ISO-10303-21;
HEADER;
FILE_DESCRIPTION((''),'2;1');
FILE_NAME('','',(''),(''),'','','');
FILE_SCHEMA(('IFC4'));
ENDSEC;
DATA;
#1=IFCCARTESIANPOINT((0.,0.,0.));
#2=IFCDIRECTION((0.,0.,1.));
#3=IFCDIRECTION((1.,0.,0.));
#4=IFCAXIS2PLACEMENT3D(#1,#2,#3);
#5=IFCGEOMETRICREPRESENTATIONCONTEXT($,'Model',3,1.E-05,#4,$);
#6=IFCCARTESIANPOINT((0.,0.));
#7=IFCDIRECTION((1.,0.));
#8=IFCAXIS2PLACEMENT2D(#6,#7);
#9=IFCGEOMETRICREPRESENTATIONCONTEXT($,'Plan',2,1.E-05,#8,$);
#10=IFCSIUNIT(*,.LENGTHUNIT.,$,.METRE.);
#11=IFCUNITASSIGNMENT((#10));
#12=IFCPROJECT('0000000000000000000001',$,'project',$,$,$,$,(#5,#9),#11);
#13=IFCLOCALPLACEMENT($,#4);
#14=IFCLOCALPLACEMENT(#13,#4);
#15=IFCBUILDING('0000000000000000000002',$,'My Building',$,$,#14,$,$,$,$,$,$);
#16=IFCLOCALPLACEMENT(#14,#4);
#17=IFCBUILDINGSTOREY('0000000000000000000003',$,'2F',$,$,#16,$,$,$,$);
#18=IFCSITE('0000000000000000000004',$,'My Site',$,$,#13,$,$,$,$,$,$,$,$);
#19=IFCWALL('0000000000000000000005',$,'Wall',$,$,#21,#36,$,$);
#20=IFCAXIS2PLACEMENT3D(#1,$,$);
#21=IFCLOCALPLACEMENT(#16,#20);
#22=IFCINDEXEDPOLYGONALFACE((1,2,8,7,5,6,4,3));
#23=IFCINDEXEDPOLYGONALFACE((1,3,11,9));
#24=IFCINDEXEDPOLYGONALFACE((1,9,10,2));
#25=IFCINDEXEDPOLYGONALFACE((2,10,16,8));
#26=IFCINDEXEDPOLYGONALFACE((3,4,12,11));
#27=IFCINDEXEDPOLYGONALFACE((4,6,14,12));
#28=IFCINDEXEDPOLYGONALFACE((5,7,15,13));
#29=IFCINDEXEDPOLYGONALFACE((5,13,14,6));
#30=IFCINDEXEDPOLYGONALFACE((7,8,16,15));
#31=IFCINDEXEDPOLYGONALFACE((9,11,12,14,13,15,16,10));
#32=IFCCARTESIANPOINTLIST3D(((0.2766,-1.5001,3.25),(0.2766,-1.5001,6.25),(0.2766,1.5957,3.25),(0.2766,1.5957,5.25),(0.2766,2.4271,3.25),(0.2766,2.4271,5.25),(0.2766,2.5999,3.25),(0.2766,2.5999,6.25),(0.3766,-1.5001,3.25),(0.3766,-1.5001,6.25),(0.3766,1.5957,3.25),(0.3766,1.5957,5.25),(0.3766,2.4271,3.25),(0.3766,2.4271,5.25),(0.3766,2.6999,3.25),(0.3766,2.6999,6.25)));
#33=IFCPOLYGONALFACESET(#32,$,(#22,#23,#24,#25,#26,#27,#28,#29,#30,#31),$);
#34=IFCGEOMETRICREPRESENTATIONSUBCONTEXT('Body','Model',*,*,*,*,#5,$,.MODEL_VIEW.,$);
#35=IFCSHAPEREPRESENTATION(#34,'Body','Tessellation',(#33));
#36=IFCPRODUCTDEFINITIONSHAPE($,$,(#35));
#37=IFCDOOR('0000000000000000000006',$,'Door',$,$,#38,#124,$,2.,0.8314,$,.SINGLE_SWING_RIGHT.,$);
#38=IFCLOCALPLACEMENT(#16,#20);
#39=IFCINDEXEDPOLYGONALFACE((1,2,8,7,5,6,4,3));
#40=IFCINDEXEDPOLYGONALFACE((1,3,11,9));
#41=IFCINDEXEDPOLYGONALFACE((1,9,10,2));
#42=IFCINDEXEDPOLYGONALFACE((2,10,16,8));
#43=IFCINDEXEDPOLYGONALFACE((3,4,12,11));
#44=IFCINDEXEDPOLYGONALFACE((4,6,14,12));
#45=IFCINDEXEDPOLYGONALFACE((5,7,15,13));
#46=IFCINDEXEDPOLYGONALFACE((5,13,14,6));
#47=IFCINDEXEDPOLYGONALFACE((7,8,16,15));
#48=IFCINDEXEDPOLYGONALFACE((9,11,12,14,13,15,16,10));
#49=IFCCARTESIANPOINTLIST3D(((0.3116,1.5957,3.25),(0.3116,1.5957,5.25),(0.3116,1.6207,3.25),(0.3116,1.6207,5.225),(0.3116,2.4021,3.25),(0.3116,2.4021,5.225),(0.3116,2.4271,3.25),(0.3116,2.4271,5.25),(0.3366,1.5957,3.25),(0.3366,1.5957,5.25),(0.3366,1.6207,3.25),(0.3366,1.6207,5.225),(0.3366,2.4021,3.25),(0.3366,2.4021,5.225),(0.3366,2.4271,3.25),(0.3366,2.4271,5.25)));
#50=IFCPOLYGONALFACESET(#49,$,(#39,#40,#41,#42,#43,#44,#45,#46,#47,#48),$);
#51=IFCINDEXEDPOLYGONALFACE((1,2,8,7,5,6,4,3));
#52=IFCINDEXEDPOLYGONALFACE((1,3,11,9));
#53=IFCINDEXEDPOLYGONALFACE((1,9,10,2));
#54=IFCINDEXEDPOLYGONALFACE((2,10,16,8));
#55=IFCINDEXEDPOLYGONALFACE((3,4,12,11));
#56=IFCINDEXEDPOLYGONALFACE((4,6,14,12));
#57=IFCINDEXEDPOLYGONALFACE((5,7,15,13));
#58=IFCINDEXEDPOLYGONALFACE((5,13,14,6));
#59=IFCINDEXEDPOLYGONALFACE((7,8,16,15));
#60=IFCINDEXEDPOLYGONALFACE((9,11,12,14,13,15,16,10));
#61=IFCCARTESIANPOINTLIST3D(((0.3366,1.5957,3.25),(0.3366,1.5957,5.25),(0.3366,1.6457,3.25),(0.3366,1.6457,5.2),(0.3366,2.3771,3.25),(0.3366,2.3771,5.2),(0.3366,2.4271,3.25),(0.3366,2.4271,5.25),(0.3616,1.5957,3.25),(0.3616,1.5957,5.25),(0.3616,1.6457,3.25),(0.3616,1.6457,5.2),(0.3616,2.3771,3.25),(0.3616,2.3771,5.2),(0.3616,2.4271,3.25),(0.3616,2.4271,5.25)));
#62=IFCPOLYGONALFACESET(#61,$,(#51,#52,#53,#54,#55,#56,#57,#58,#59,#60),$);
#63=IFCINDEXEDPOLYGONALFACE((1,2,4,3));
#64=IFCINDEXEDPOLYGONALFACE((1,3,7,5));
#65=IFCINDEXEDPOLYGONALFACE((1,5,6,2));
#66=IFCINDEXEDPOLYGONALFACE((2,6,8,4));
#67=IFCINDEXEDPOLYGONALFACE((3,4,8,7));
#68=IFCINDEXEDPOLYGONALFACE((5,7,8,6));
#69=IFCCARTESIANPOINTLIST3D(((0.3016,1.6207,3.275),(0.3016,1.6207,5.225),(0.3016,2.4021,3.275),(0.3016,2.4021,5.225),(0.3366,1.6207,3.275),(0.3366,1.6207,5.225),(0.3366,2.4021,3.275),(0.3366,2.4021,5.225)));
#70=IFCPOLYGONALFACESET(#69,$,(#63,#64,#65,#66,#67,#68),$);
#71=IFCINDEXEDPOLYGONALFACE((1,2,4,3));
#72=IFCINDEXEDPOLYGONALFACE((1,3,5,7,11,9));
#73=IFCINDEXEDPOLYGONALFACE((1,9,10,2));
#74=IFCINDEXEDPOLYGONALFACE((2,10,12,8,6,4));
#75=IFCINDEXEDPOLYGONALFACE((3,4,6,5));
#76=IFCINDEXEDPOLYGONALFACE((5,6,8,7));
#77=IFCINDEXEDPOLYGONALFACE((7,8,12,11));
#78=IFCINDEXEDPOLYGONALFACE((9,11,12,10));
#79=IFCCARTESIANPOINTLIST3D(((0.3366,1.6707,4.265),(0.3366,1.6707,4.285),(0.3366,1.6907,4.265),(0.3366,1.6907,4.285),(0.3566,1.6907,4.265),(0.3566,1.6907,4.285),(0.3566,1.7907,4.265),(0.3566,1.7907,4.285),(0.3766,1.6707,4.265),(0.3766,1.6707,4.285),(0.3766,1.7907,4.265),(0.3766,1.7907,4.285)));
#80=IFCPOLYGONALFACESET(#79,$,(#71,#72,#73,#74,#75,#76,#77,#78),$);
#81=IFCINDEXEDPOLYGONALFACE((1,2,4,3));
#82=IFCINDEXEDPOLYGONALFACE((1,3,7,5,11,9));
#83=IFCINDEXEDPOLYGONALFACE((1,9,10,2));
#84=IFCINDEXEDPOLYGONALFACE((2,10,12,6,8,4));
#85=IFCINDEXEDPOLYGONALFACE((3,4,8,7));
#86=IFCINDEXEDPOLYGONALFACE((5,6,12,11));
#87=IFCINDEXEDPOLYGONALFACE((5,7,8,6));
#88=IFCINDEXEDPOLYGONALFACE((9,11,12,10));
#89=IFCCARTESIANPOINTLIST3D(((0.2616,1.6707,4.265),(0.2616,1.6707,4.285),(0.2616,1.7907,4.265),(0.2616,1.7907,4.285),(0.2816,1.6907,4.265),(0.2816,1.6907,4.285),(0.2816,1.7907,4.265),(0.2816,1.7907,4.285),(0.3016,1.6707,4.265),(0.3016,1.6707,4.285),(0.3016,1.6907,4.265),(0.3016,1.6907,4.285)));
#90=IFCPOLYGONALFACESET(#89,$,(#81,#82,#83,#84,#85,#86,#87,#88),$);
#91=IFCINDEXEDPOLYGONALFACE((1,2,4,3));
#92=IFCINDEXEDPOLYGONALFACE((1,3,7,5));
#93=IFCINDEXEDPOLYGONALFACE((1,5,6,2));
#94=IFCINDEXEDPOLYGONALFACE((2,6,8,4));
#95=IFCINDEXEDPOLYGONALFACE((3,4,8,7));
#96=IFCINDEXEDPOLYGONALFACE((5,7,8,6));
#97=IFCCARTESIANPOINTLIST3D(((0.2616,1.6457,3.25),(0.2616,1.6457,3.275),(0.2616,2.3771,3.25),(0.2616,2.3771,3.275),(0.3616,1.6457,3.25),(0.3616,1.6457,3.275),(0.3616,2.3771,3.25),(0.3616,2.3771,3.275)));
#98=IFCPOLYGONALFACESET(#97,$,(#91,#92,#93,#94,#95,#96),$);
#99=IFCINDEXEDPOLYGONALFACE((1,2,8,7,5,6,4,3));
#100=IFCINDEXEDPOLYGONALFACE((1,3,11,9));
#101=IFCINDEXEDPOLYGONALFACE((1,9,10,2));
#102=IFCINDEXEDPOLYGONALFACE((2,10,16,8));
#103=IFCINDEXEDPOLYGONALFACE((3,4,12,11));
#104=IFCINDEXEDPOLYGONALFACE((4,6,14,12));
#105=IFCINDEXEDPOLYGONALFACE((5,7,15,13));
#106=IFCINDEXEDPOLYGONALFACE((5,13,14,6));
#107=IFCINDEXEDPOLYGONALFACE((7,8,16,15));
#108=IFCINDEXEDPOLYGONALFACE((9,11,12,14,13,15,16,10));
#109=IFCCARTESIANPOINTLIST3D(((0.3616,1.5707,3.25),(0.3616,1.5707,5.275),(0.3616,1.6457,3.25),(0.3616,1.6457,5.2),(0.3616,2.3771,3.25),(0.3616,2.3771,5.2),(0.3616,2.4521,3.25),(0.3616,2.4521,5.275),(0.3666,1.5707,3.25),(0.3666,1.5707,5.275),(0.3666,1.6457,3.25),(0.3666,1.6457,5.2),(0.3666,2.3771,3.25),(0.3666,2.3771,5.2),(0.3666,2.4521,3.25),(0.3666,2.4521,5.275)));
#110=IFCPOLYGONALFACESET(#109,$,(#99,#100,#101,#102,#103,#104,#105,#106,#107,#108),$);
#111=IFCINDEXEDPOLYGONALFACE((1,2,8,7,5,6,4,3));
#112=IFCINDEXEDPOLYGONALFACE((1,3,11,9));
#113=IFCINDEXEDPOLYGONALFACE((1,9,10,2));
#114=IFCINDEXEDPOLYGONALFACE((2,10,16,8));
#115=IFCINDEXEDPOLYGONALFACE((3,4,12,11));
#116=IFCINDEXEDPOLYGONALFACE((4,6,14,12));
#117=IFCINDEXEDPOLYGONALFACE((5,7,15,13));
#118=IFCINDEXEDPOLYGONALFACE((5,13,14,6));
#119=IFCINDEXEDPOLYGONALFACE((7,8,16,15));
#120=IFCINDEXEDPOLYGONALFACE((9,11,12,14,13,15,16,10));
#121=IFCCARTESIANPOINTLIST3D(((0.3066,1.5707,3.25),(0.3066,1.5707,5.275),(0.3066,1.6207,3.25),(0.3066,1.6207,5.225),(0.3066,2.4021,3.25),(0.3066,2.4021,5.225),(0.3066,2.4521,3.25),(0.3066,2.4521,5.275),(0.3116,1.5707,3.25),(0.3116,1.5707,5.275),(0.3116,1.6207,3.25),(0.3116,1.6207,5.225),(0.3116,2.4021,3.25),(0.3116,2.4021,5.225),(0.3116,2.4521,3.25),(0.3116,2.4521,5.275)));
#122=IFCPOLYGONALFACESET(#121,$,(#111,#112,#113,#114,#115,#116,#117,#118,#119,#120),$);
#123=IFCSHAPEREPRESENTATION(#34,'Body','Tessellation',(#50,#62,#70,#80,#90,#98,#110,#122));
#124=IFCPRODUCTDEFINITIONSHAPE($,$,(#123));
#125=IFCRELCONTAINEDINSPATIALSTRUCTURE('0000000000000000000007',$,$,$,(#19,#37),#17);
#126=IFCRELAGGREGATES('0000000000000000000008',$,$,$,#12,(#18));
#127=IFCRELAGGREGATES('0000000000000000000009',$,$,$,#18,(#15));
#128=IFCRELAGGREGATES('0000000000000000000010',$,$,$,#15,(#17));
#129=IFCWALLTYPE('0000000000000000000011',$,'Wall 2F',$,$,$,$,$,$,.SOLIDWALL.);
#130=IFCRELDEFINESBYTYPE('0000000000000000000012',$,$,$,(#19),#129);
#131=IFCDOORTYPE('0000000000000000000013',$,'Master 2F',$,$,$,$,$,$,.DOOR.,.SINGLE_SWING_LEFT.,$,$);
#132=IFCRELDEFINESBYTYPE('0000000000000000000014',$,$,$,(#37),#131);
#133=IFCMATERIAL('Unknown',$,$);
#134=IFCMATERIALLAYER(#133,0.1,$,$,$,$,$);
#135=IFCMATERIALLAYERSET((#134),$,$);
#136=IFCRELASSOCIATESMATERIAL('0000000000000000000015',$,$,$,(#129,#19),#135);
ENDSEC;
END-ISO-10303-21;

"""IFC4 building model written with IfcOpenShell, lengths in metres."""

from ifc_helpers import new_model, entity, si_unit, frame, origin_with_axes, origin_2d_with_axis, place, context, subcontext, project, spatial, line, indexed_curve, outline, extrude, shape, source, transform, mapped, material, layer, layer_set, layer_usage, type_object, type_shapes, element, fill, save


model = new_model("IFC4")

# Units and contexts
model_context = context("Model", 3, precision=1e-05, world=origin_with_axes())
plan_context = context("Plan", 2, precision=1e-05, world=origin_2d_with_axis())
body_context_1 = subcontext(model_context, "Body", "Model", "MODEL_VIEW")
body_context_2 = subcontext(plan_context, "Body", "Plan", "PLAN_VIEW")
ifc_project = project(units=[si_unit("LENGTHUNIT", "METRE")], contexts=[model_context, plan_context])

# Site, building, storey
site_placement = place(None, origin_with_axes())
site = spatial("IfcSite", under=ifc_project, at=site_placement, Name="My Site")
building_placement = place(site_placement, origin_with_axes())
building = spatial("IfcBuilding", under=site, at=building_placement, Name="My Building")
storey_placement = place(building_placement, origin_with_axes())
storey = spatial("IfcBuildingStorey", under=building, at=storey_placement, Name="2F")

# Shared definitions
ifc_material = material(Name="Unknown")

# Shared definitions
ifc_layer = layer(ifc_material, 0.1)
ifc_layer_set = layer_set([ifc_layer])
wall_type = type_object("IfcWallType", Name="Wall 2F", PredefinedType="SOLIDWALL", material=ifc_layer_set)

# Wall, opening, door
ifc_layer_usage_1 = layer_usage(ifc_layer_set, "AXIS2", "POSITIVE", 0.0)
wall_1_placement = place(storey_placement, frame((0.3766, -1.6001, 3.25), z_axis=(0.0, 0.0, 1.0), x_axis=(0.0, 1.0, 0.0)))
wall_1 = element("IfcWall", 1, at=wall_1_placement, inside=storey, type_object=wall_type, material=ifc_layer_usage_1, Name="Wall", context=body_context_1, shape_type="SweptSolid", body=[
    extrude(outline(indexed_curve([(0.1, 0.0), (0.1, 0.1), (4.2, 0.1), (4.3, 0.0)], segments=[line(1, 2, 3, 4, 1)])), origin_with_axes(), (0.0, 0.0, 1.0), 3.0),
])
shared_shape_1 = source(origin_with_axes(), body_context_1, "Body", "SweptSolid", [
    extrude(outline(indexed_curve([(0.0, 0.0), (0.8314, 0.0), (0.8314, 2.0), (0.0, 2.0)], segments=[line(1, 2, 3, 4, 1)])), frame((0.0, -0.6, 0.0), z_axis=(0.0, -1.0, 0.0), x_axis=(1.0, 0.0, 0.0)), (0.0, 0.0, -1.0), 1.2),
])
opening_1_placement = place(wall_1_placement, frame((3.1958, 0.015, 0.0), z_axis=(0.0, 0.0, 1.0), x_axis=(1.0, 0.0, 0.0)))
opening_1 = element("IfcOpeningElement", 2, at=opening_1_placement, cuts=wall_1, PredefinedType="OPENING", context=body_context_1, shape_type="MappedRepresentation", body=[
    mapped(shared_shape_1, transform((0.0, 0.0, 0.0), x_axis=(1.0, 0.0, 0.0), y_axis=(0.0, 1.0, 0.0), z_axis=(0.0, 0.0, 1.0), scale=1.0)),
])
door_type_1 = type_object("IfcDoorType", Name="Master 2F", OperationType="SINGLE_SWING_LEFT", PredefinedType="DOOR")
shared_shape_2 = source(origin_with_axes(), body_context_1, "Body", "SweptSolid", [
    extrude(outline(indexed_curve([(0.0, 0.0), (0.0, 2.0), (0.8314, 2.0), (0.8314, 0.0), (0.8064, 0.0), (0.8064, 1.975), (0.025, 1.975), (0.025, 0.0)], segments=[line(1, 2, 3, 4, 5, 6, 7, 8, 1)])), frame((0.0, 0.025, 0.0), z_axis=(0.0, -1.0, 0.0), x_axis=(1.0, 0.0, 0.0)), (0.0, 0.0, -1.0), 0.025),
    extrude(outline(indexed_curve([(0.0, 0.0), (0.0, 2.0), (0.8314, 2.0), (0.8314, 0.0), (0.7814, 0.0), (0.7814, 1.95), (0.05, 1.95), (0.05, 0.0)], segments=[line(1, 2, 3, 4, 5, 6, 7, 8, 1)])), frame((0.0, 0.0, 0.0), z_axis=(0.0, -1.0, 0.0), x_axis=(1.0, 0.0, 0.0)), (0.0, 0.0, -1.0), 0.025),
    extrude(outline(indexed_curve([(0.0, 0.0), (0.7814, 0.0), (0.7814, 0.035), (0.0, 0.035)], segments=[line(1, 2, 3, 4, 1)])), frame((0.025, 0.025, 0.025), z_axis=(0.0, 0.0, 1.0), x_axis=(1.0, 0.0, 0.0)), (0.0, 0.0, 1.0), 1.95),
    extrude(outline(indexed_curve([(0.0, 0.0), (0.0, -0.04), (0.12, -0.04), (0.12, -0.02), (0.02, -0.02), (0.02, 0.0)], segments=[line(1, 2, 3, 4, 5, 6, 1)])), frame((0.075, 0.025, 1.015), z_axis=(0.0, 0.0, 1.0), x_axis=(1.0, 0.0, 0.0)), (0.0, 0.0, 1.0), 0.02),
    extrude(outline(indexed_curve([(0.0, 0.0), (0.0, 0.04), (0.12, 0.04), (0.12, 0.02), (0.02, 0.02), (0.02, 0.0)], segments=[line(1, 2, 3, 4, 5, 6, 1)])), frame((0.075, 0.06, 1.015), z_axis=(0.0, 0.0, 1.0), x_axis=(1.0, 0.0, 0.0)), (0.0, 0.0, 1.0), 0.02),
    extrude(outline(indexed_curve([(0.0, 0.0), (0.7314, 0.0), (0.7314, 0.1), (0.0, 0.1)], segments=[line(1, 2, 3, 4, 1)])), frame((0.05, 0.0, 0.0), z_axis=(0.0, 0.0, 1.0), x_axis=(1.0, 0.0, 0.0)), (0.0, 0.0, 1.0), 0.025),
    extrude(outline(indexed_curve([(0.0, 0.0), (0.0, 2.025), (0.8814, 2.025), (0.8814, 0.0), (0.8064, 0.0), (0.8064, 1.95), (0.075, 1.95), (0.075, 0.0)], segments=[line(1, 2, 3, 4, 5, 6, 7, 8, 1)])), frame((-0.025, -0.005, 0.0), z_axis=(0.0, -1.0, 0.0), x_axis=(1.0, 0.0, 0.0)), (0.0, 0.0, -1.0), 0.005),
    extrude(outline(indexed_curve([(0.0, 0.0), (0.0, 2.025), (0.8814, 2.025), (0.8814, 0.0), (0.8314, 0.0), (0.8314, 1.975), (0.05, 1.975), (0.05, 0.0)], segments=[line(1, 2, 3, 4, 5, 6, 7, 8, 1)])), frame((-0.025, 0.05, 0.0), z_axis=(0.0, -1.0, 0.0), x_axis=(1.0, 0.0, 0.0)), (0.0, 0.0, -1.0), 0.005),
])
shared_shape_3 = source(origin_with_axes(), body_context_2, "Body", "Curve2D", [
    entity("IfcIndexedPolyCurve", entity("IfcCartesianPointList2D", [[0.0, 0.0], [0.0, 0.05], [0.025, 0.05], [0.025, 0.025], [0.05, 0.025], [0.05, 0.0]]), [entity("IfcLineIndex", [1, 2, 3, 4, 5, 6, 1])]),
    entity("IfcIndexedPolyCurve", entity("IfcCartesianPointList2D", [[0.8314, 0.0], [0.8314, 0.05], [0.8064, 0.05], [0.8064, 0.025], [0.7814, 0.025], [0.7814, 0.0]]), [entity("IfcLineIndex", [1, 2, 3, 4, 5, 6, 1])]),
    entity("IfcTrimmedCurve", entity("IfcEllipse", entity("IfcAxis2Placement2D", entity("IfcCartesianPoint", [0.7714, 0.05]), entity("IfcDirection", [1.0, 0.0])), 0.7464, 0.7814), [entity("IfcCartesianPoint", [0.7714, 0.8314])], [entity("IfcCartesianPoint", [0.025, 0.05])], True, "CARTESIAN"),
    entity("IfcIndexedPolyCurve", entity("IfcCartesianPointList2D", [[0.8064, 0.05], [0.7714, 0.05], [0.7714, 0.8314], [0.8064, 0.8314]]), [entity("IfcLineIndex", [1, 2, 3, 4, 1])]),
])
type_shapes(door_type_1, [shared_shape_2, shared_shape_3])
door_1_placement = place(opening_1_placement, frame((0.0, 0.0, 0.0), z_axis=(0.0, 0.0, 1.0), x_axis=(1.0, 0.0, 0.0)))
door_1 = element("IfcDoor", 3, at=door_1_placement, inside=storey, type_object=door_type_1, Name="Door", OperationType="SINGLE_SWING_RIGHT", OverallHeight=2.0, OverallWidth=0.8314, shapes=[
    shape(body_context_1, "Body", "MappedRepresentation", [mapped(shared_shape_2, transform((0.0, 0.0, 0.0), x_axis=(1.0, 0.0, 0.0), y_axis=(0.0, 1.0, 0.0), z_axis=(0.0, 0.0, 1.0), scale=1.0))]),
    shape(body_context_2, "Body", "MappedRepresentation", [mapped(shared_shape_3, transform((0.0, 0.0, 0.0), x_axis=(1.0, 0.0, 0.0), y_axis=(0.0, 1.0, 0.0), z_axis=(0.0, 0.0, 1.0), scale=1.0))]),
])
fill(opening_1, door_1)

save(model, "model.ifc")
